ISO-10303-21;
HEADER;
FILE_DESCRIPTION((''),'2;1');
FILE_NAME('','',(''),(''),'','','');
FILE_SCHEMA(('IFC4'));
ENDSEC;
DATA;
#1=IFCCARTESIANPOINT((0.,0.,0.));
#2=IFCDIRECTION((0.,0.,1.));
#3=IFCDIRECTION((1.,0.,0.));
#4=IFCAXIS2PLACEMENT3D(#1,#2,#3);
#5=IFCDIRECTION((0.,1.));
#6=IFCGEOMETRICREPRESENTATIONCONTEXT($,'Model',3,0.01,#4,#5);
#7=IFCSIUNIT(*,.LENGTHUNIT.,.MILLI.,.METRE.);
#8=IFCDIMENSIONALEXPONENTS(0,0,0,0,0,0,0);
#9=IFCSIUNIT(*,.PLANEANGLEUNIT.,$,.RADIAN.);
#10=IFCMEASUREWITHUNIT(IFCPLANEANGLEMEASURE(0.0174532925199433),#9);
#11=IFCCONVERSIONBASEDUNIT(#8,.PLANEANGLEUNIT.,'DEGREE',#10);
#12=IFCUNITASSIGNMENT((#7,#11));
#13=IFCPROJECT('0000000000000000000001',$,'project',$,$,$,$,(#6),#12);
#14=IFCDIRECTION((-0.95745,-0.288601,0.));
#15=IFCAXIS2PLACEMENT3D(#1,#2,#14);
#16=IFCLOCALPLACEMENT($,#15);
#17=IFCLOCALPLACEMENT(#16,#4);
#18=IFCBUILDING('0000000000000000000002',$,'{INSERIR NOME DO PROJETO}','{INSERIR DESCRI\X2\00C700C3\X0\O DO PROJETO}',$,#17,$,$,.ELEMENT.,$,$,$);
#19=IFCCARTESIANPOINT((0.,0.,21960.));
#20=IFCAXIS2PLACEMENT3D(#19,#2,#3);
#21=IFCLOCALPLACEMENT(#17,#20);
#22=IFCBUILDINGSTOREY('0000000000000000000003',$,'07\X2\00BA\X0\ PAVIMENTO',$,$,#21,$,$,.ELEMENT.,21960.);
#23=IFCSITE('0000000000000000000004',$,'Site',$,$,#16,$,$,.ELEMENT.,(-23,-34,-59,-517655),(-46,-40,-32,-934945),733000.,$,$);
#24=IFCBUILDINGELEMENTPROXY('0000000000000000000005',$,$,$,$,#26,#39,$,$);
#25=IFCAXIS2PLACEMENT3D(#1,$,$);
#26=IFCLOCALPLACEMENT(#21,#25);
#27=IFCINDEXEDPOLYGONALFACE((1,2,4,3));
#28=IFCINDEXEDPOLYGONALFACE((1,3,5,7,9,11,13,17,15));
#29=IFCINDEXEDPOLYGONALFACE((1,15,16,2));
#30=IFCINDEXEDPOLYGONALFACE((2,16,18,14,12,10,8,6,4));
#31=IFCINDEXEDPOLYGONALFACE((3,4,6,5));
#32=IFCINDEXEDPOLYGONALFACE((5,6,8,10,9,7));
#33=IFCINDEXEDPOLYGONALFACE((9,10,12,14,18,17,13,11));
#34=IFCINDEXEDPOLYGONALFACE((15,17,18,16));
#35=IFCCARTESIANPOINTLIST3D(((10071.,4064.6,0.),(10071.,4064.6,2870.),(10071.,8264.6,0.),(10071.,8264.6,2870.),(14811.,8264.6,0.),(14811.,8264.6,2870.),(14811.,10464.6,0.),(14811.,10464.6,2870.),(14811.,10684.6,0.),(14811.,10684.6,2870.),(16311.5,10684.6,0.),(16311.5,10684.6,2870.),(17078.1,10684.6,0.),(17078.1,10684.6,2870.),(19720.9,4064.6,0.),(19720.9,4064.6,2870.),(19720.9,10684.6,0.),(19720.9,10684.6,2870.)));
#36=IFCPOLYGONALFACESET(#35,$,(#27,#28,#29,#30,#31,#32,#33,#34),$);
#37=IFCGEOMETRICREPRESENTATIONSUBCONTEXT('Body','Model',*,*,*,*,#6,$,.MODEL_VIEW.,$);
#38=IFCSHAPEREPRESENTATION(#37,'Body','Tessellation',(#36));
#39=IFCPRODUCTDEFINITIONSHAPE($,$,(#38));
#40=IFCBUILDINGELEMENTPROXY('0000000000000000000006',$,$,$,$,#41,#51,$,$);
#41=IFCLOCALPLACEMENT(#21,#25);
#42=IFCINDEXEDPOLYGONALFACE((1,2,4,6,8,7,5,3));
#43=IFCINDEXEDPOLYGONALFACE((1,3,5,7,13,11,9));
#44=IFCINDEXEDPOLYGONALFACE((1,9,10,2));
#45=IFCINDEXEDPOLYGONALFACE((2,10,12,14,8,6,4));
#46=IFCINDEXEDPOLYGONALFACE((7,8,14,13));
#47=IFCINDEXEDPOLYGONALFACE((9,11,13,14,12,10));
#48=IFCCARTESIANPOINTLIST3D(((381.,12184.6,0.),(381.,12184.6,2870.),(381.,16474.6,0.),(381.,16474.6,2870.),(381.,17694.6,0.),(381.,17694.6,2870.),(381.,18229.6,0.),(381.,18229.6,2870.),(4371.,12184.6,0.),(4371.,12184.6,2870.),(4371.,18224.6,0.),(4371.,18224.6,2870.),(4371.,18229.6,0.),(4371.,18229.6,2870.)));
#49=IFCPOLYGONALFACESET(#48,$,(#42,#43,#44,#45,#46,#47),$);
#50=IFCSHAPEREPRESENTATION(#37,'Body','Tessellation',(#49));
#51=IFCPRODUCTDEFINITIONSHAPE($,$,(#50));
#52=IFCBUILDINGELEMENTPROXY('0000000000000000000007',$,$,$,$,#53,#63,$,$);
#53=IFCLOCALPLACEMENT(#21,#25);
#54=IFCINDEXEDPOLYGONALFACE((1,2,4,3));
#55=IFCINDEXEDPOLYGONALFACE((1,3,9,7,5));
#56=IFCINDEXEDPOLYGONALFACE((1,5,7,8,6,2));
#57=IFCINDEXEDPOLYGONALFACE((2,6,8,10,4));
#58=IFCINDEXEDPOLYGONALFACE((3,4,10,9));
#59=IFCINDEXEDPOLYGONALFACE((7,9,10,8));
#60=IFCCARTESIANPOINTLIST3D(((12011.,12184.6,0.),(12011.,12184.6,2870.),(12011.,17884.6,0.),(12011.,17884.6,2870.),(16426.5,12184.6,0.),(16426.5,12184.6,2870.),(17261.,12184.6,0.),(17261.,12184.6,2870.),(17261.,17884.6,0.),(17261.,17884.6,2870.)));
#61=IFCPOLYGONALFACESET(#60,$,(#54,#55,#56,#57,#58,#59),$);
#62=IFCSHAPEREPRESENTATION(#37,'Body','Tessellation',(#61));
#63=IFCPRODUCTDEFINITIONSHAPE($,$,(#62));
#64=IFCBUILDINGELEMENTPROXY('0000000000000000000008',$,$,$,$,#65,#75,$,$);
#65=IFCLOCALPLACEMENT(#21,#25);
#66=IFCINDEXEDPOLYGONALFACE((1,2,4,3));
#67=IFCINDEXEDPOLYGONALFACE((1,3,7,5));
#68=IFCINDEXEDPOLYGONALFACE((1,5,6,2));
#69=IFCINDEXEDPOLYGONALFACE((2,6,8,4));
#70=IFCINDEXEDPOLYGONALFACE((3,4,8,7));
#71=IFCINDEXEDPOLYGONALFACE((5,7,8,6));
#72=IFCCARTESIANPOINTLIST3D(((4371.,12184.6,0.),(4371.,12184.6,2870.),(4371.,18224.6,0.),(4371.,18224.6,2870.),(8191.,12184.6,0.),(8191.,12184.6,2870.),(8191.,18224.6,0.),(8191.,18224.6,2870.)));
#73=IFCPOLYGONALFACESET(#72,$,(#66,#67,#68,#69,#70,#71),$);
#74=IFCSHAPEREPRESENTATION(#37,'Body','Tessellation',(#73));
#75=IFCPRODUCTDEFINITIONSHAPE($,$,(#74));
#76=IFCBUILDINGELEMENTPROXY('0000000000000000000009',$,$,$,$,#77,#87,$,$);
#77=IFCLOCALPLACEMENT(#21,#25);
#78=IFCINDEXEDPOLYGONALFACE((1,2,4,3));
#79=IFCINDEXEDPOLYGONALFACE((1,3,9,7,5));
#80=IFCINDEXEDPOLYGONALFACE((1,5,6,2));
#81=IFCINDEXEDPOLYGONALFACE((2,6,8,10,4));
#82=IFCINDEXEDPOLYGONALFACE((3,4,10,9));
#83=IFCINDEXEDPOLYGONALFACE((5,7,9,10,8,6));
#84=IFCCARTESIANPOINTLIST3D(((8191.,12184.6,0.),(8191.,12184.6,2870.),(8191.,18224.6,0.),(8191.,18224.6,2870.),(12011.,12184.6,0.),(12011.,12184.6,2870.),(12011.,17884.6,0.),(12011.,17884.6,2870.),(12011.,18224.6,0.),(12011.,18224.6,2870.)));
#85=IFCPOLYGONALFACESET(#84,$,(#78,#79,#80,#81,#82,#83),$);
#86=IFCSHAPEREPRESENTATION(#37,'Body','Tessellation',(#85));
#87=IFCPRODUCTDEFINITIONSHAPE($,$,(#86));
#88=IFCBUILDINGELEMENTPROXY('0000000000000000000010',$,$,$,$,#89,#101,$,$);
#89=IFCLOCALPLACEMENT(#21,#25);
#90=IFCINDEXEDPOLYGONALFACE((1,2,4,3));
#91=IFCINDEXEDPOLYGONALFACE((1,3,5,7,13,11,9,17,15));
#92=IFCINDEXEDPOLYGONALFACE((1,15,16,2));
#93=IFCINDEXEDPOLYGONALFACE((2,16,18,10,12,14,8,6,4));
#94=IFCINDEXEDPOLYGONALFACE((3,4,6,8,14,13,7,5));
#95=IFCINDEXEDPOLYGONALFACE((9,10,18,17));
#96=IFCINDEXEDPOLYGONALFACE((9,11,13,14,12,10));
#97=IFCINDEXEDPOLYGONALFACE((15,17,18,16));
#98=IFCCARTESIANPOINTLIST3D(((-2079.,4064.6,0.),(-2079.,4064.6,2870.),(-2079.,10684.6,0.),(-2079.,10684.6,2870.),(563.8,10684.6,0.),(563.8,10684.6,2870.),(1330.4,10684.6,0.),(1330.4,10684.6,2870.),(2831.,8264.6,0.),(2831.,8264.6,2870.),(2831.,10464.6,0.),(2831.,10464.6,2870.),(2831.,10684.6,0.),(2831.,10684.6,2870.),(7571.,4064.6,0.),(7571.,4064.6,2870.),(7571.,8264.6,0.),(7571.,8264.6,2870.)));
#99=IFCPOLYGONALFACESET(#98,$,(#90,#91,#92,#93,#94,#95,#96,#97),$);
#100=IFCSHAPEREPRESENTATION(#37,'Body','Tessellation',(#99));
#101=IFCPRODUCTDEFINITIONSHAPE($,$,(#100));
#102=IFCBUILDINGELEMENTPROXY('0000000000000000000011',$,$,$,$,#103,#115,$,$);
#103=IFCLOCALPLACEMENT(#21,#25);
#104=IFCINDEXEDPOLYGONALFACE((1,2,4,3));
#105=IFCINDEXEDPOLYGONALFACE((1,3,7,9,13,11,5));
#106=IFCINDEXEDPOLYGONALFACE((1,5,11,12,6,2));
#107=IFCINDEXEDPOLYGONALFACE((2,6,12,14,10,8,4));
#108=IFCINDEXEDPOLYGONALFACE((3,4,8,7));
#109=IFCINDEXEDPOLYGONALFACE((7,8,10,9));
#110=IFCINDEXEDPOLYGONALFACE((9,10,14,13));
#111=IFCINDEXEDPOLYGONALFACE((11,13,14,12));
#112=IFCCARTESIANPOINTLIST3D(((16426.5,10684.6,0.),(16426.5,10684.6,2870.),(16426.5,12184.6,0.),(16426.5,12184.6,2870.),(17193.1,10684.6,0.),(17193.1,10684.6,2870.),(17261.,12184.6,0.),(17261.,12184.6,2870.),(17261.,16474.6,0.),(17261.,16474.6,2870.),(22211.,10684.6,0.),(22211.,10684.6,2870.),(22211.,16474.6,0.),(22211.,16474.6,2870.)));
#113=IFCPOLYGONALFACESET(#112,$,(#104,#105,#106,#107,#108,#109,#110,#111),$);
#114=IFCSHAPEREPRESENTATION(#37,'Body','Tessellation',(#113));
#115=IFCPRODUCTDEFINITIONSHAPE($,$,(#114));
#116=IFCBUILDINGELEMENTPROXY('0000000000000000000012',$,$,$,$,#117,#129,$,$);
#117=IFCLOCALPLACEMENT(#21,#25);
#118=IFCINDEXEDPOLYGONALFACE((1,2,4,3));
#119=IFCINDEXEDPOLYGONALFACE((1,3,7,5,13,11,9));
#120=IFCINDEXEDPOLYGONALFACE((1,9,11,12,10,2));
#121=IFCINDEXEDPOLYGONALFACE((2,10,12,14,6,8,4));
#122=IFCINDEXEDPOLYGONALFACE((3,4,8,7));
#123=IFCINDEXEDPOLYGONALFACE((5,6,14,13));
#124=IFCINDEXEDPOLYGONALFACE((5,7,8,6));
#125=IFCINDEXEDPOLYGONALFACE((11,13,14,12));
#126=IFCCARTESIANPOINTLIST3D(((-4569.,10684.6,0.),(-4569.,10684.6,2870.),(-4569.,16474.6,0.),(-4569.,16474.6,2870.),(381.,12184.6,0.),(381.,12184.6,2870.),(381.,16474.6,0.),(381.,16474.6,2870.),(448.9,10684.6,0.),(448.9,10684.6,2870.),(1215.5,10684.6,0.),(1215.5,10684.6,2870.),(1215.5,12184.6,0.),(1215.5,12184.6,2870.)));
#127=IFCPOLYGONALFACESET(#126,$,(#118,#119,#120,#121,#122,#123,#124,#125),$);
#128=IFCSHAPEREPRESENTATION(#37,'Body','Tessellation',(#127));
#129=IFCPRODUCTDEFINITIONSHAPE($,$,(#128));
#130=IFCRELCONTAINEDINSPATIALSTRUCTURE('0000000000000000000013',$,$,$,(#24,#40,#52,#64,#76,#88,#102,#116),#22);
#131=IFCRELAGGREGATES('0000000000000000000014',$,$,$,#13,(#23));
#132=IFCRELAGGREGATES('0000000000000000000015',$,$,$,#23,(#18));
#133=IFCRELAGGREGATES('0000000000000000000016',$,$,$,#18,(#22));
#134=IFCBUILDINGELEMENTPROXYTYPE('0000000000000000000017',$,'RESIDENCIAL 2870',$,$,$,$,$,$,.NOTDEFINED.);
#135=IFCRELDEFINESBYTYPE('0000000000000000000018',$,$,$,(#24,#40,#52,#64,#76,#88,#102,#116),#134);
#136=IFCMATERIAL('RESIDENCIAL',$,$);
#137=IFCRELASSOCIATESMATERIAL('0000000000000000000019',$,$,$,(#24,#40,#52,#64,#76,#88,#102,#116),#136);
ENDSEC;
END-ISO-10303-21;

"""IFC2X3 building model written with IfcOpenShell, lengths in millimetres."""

from ifc_helpers import new_model, entity, si_unit, converted_unit, direction, frame, origin_with_axes, place, context, subcontext, project, spatial, polyline, outline, extrude, material, type_object, element, save


model = new_model("IFC2X3")

# Units and contexts
model_context = context("Model", 3, precision=0.01, world=origin_with_axes(), true_north=direction((0.0, 1.0)))
body_context = subcontext(model_context, "Body", "Model", "MODEL_VIEW")
ifc_project = project(units=[si_unit("LENGTHUNIT", "METRE", prefix="MILLI"), converted_unit("PLANEANGLEUNIT", "DEGREE", entity("IfcPlaneAngleMeasure", 0.0174532925199433), si_unit("PLANEANGLEUNIT", "RADIAN"), dimensions=[0, 0, 0, 0, 0, 0, 0])], contexts=[model_context])

# Site, building, storey
site_placement = place(None, frame((0.0, 0.0, 0.0), z_axis=(0.0, 0.0, 1.0), x_axis=(-0.95745, -0.288601, 0.0)))
site = spatial("IfcSite", under=ifc_project, at=site_placement, Name="Site", CompositionType="ELEMENT", RefLatitude=(-23, -34, -59, -517655), RefLongitude=(-46, -40, -32, -934945), RefElevation=733000.0)
building_placement = place(site_placement, origin_with_axes())
building = spatial("IfcBuilding", under=site, at=building_placement, Name="{INSERIR NOME DO PROJETO}", Description="{INSERIR DESCRIÇÃO DO PROJETO}", CompositionType="ELEMENT")
storey_placement = place(building_placement, frame((0.0, 0.0, 21960.0), z_axis=(0.0, 0.0, 1.0), x_axis=(1.0, 0.0, 0.0)))
storey = spatial("IfcBuildingStorey", under=building, at=storey_placement, Name="07º PAVIMENTO", CompositionType="ELEMENT", Elevation=21960.0)

# Building element proxies
ifc_material_1 = material(Name="RESIDENCIAL")
building_element_proxy_type_1 = type_object("IfcBuildingElementProxyType", Name="RESIDENCIAL 2870", PredefinedType="NOTDEFINED")
proxy_1_placement = place(storey_placement, frame((19720.9, 4064.6, 0.0), z_axis=(0.0, 0.0, 1.0), x_axis=(1.0, 0.0, 0.0)))
element("IfcBuildingElementProxy", 1, at=proxy_1_placement, inside=storey, type_object=building_element_proxy_type_1, material=ifc_material_1, context=body_context, shape_type="SweptSolid", body=[
    extrude(outline(polyline([(0.0, 0.0), (0.0, 6620.0), (-2642.8, 6620.0), (-3409.4, 6620.0), (-4910.0, 6620.0), (-4910.0, 6400.0), (-4910.0, 4200.0), (-9650.0, 4200.0), (-9650.0, 0.0), (0.0, 0.0)])), origin_with_axes(), (0.0, 0.0, 1.0), 2870.0),
])
proxy_2_placement = place(storey_placement, frame((381.0, 16474.6, 0.0), z_axis=(0.0, 0.0, 1.0), x_axis=(1.0, 0.0, 0.0)))
element("IfcBuildingElementProxy", 2, at=proxy_2_placement, inside=storey, type_object=building_element_proxy_type_1, material=ifc_material_1, context=body_context, shape_type="SweptSolid", body=[
    extrude(outline(polyline([(0.0, 0.0), (0.0, -4290.0), (3990.0, -4290.0), (3990.0, 1750.0), (3990.0, 1755.0), (0.0, 1755.0), (0.0, 1220.0), (0.0, 0.0)])), origin_with_axes(), (0.0, 0.0, 1.0), 2870.0),
])
proxy_3_placement = place(storey_placement, frame((12011.0, 12184.6, 0.0), z_axis=(0.0, 0.0, 1.0), x_axis=(1.0, 0.0, 0.0)))
element("IfcBuildingElementProxy", 3, at=proxy_3_placement, inside=storey, type_object=building_element_proxy_type_1, material=ifc_material_1, context=body_context, shape_type="SweptSolid", body=[
    extrude(outline(polyline([(0.0, 0.0), (4415.5, 0.0), (5250.0, 0.0), (5250.0, 5700.0), (0.0, 5700.0), (0.0, 0.0)])), origin_with_axes(), (0.0, 0.0, 1.0), 2870.0),
])
proxy_4_placement = place(storey_placement, frame((4371.0, 18224.6, 0.0), z_axis=(0.0, 0.0, 1.0), x_axis=(1.0, 0.0, 0.0)))
element("IfcBuildingElementProxy", 4, at=proxy_4_placement, inside=storey, type_object=building_element_proxy_type_1, material=ifc_material_1, context=body_context, shape_type="SweptSolid", body=[
    extrude(outline(polyline([(0.0, 0.0), (0.0, -6040.0), (3820.0, -6040.0), (3820.0, 0.0), (0.0, 0.0)])), origin_with_axes(), (0.0, 0.0, 1.0), 2870.0),
])
proxy_5_placement = place(storey_placement, frame((8191.0, 18224.6, 0.0), z_axis=(0.0, 0.0, 1.0), x_axis=(1.0, 0.0, 0.0)))
element("IfcBuildingElementProxy", 5, at=proxy_5_placement, inside=storey, type_object=building_element_proxy_type_1, material=ifc_material_1, context=body_context, shape_type="SweptSolid", body=[
    extrude(outline(polyline([(0.0, 0.0), (0.0, -6040.0), (3820.0, -6040.0), (3820.0, -340.0), (3820.0, 0.0), (0.0, 0.0)])), origin_with_axes(), (0.0, 0.0, 1.0), 2870.0),
])
proxy_6_placement = place(storey_placement, frame((-2079.0, 4064.6, 0.0), z_axis=(0.0, 0.0, 1.0), x_axis=(1.0, 0.0, 0.0)))
element("IfcBuildingElementProxy", 6, at=proxy_6_placement, inside=storey, type_object=building_element_proxy_type_1, material=ifc_material_1, context=body_context, shape_type="SweptSolid", body=[
    extrude(outline(polyline([(0.0, 0.0), (9650.0, 0.0), (9650.0, 4200.0), (4910.0, 4200.0), (4910.0, 6400.0), (4910.0, 6620.0), (3409.4, 6620.0), (2642.8, 6620.0), (0.0, 6620.0), (0.0, 0.0)])), origin_with_axes(), (0.0, 0.0, 1.0), 2870.0),
])
proxy_7_placement = place(storey_placement, frame((17261.0, 12184.6, 0.0), z_axis=(0.0, 0.0, 1.0), x_axis=(1.0, 0.0, 0.0)))
element("IfcBuildingElementProxy", 7, at=proxy_7_placement, inside=storey, type_object=building_element_proxy_type_1, material=ifc_material_1, context=body_context, shape_type="SweptSolid", body=[
    extrude(outline(polyline([(0.0, 0.0), (-834.5, 0.0), (-834.5, -1500.0), (-67.9, -1500.0), (4950.0, -1500.0), (4950.0, 4290.0), (0.0, 4290.0), (0.0, 0.0)])), origin_with_axes(), (0.0, 0.0, 1.0), 2870.0),
])
proxy_8_placement = place(storey_placement, frame((-4569.0, 16474.6, 0.0), z_axis=(0.0, 0.0, 1.0), x_axis=(1.0, 0.0, 0.0)))
element("IfcBuildingElementProxy", 8, at=proxy_8_placement, inside=storey, type_object=building_element_proxy_type_1, material=ifc_material_1, context=body_context, shape_type="SweptSolid", body=[
    extrude(outline(polyline([(0.0, 0.0), (0.0, -5790.0), (5017.9, -5790.0), (5784.5, -5790.0), (5784.5, -4290.0), (4950.0, -4290.0), (4950.0, 0.0), (0.0, 0.0)])), origin_with_axes(), (0.0, 0.0, 1.0), 2870.0),
])

save(model, "model.ifc")
